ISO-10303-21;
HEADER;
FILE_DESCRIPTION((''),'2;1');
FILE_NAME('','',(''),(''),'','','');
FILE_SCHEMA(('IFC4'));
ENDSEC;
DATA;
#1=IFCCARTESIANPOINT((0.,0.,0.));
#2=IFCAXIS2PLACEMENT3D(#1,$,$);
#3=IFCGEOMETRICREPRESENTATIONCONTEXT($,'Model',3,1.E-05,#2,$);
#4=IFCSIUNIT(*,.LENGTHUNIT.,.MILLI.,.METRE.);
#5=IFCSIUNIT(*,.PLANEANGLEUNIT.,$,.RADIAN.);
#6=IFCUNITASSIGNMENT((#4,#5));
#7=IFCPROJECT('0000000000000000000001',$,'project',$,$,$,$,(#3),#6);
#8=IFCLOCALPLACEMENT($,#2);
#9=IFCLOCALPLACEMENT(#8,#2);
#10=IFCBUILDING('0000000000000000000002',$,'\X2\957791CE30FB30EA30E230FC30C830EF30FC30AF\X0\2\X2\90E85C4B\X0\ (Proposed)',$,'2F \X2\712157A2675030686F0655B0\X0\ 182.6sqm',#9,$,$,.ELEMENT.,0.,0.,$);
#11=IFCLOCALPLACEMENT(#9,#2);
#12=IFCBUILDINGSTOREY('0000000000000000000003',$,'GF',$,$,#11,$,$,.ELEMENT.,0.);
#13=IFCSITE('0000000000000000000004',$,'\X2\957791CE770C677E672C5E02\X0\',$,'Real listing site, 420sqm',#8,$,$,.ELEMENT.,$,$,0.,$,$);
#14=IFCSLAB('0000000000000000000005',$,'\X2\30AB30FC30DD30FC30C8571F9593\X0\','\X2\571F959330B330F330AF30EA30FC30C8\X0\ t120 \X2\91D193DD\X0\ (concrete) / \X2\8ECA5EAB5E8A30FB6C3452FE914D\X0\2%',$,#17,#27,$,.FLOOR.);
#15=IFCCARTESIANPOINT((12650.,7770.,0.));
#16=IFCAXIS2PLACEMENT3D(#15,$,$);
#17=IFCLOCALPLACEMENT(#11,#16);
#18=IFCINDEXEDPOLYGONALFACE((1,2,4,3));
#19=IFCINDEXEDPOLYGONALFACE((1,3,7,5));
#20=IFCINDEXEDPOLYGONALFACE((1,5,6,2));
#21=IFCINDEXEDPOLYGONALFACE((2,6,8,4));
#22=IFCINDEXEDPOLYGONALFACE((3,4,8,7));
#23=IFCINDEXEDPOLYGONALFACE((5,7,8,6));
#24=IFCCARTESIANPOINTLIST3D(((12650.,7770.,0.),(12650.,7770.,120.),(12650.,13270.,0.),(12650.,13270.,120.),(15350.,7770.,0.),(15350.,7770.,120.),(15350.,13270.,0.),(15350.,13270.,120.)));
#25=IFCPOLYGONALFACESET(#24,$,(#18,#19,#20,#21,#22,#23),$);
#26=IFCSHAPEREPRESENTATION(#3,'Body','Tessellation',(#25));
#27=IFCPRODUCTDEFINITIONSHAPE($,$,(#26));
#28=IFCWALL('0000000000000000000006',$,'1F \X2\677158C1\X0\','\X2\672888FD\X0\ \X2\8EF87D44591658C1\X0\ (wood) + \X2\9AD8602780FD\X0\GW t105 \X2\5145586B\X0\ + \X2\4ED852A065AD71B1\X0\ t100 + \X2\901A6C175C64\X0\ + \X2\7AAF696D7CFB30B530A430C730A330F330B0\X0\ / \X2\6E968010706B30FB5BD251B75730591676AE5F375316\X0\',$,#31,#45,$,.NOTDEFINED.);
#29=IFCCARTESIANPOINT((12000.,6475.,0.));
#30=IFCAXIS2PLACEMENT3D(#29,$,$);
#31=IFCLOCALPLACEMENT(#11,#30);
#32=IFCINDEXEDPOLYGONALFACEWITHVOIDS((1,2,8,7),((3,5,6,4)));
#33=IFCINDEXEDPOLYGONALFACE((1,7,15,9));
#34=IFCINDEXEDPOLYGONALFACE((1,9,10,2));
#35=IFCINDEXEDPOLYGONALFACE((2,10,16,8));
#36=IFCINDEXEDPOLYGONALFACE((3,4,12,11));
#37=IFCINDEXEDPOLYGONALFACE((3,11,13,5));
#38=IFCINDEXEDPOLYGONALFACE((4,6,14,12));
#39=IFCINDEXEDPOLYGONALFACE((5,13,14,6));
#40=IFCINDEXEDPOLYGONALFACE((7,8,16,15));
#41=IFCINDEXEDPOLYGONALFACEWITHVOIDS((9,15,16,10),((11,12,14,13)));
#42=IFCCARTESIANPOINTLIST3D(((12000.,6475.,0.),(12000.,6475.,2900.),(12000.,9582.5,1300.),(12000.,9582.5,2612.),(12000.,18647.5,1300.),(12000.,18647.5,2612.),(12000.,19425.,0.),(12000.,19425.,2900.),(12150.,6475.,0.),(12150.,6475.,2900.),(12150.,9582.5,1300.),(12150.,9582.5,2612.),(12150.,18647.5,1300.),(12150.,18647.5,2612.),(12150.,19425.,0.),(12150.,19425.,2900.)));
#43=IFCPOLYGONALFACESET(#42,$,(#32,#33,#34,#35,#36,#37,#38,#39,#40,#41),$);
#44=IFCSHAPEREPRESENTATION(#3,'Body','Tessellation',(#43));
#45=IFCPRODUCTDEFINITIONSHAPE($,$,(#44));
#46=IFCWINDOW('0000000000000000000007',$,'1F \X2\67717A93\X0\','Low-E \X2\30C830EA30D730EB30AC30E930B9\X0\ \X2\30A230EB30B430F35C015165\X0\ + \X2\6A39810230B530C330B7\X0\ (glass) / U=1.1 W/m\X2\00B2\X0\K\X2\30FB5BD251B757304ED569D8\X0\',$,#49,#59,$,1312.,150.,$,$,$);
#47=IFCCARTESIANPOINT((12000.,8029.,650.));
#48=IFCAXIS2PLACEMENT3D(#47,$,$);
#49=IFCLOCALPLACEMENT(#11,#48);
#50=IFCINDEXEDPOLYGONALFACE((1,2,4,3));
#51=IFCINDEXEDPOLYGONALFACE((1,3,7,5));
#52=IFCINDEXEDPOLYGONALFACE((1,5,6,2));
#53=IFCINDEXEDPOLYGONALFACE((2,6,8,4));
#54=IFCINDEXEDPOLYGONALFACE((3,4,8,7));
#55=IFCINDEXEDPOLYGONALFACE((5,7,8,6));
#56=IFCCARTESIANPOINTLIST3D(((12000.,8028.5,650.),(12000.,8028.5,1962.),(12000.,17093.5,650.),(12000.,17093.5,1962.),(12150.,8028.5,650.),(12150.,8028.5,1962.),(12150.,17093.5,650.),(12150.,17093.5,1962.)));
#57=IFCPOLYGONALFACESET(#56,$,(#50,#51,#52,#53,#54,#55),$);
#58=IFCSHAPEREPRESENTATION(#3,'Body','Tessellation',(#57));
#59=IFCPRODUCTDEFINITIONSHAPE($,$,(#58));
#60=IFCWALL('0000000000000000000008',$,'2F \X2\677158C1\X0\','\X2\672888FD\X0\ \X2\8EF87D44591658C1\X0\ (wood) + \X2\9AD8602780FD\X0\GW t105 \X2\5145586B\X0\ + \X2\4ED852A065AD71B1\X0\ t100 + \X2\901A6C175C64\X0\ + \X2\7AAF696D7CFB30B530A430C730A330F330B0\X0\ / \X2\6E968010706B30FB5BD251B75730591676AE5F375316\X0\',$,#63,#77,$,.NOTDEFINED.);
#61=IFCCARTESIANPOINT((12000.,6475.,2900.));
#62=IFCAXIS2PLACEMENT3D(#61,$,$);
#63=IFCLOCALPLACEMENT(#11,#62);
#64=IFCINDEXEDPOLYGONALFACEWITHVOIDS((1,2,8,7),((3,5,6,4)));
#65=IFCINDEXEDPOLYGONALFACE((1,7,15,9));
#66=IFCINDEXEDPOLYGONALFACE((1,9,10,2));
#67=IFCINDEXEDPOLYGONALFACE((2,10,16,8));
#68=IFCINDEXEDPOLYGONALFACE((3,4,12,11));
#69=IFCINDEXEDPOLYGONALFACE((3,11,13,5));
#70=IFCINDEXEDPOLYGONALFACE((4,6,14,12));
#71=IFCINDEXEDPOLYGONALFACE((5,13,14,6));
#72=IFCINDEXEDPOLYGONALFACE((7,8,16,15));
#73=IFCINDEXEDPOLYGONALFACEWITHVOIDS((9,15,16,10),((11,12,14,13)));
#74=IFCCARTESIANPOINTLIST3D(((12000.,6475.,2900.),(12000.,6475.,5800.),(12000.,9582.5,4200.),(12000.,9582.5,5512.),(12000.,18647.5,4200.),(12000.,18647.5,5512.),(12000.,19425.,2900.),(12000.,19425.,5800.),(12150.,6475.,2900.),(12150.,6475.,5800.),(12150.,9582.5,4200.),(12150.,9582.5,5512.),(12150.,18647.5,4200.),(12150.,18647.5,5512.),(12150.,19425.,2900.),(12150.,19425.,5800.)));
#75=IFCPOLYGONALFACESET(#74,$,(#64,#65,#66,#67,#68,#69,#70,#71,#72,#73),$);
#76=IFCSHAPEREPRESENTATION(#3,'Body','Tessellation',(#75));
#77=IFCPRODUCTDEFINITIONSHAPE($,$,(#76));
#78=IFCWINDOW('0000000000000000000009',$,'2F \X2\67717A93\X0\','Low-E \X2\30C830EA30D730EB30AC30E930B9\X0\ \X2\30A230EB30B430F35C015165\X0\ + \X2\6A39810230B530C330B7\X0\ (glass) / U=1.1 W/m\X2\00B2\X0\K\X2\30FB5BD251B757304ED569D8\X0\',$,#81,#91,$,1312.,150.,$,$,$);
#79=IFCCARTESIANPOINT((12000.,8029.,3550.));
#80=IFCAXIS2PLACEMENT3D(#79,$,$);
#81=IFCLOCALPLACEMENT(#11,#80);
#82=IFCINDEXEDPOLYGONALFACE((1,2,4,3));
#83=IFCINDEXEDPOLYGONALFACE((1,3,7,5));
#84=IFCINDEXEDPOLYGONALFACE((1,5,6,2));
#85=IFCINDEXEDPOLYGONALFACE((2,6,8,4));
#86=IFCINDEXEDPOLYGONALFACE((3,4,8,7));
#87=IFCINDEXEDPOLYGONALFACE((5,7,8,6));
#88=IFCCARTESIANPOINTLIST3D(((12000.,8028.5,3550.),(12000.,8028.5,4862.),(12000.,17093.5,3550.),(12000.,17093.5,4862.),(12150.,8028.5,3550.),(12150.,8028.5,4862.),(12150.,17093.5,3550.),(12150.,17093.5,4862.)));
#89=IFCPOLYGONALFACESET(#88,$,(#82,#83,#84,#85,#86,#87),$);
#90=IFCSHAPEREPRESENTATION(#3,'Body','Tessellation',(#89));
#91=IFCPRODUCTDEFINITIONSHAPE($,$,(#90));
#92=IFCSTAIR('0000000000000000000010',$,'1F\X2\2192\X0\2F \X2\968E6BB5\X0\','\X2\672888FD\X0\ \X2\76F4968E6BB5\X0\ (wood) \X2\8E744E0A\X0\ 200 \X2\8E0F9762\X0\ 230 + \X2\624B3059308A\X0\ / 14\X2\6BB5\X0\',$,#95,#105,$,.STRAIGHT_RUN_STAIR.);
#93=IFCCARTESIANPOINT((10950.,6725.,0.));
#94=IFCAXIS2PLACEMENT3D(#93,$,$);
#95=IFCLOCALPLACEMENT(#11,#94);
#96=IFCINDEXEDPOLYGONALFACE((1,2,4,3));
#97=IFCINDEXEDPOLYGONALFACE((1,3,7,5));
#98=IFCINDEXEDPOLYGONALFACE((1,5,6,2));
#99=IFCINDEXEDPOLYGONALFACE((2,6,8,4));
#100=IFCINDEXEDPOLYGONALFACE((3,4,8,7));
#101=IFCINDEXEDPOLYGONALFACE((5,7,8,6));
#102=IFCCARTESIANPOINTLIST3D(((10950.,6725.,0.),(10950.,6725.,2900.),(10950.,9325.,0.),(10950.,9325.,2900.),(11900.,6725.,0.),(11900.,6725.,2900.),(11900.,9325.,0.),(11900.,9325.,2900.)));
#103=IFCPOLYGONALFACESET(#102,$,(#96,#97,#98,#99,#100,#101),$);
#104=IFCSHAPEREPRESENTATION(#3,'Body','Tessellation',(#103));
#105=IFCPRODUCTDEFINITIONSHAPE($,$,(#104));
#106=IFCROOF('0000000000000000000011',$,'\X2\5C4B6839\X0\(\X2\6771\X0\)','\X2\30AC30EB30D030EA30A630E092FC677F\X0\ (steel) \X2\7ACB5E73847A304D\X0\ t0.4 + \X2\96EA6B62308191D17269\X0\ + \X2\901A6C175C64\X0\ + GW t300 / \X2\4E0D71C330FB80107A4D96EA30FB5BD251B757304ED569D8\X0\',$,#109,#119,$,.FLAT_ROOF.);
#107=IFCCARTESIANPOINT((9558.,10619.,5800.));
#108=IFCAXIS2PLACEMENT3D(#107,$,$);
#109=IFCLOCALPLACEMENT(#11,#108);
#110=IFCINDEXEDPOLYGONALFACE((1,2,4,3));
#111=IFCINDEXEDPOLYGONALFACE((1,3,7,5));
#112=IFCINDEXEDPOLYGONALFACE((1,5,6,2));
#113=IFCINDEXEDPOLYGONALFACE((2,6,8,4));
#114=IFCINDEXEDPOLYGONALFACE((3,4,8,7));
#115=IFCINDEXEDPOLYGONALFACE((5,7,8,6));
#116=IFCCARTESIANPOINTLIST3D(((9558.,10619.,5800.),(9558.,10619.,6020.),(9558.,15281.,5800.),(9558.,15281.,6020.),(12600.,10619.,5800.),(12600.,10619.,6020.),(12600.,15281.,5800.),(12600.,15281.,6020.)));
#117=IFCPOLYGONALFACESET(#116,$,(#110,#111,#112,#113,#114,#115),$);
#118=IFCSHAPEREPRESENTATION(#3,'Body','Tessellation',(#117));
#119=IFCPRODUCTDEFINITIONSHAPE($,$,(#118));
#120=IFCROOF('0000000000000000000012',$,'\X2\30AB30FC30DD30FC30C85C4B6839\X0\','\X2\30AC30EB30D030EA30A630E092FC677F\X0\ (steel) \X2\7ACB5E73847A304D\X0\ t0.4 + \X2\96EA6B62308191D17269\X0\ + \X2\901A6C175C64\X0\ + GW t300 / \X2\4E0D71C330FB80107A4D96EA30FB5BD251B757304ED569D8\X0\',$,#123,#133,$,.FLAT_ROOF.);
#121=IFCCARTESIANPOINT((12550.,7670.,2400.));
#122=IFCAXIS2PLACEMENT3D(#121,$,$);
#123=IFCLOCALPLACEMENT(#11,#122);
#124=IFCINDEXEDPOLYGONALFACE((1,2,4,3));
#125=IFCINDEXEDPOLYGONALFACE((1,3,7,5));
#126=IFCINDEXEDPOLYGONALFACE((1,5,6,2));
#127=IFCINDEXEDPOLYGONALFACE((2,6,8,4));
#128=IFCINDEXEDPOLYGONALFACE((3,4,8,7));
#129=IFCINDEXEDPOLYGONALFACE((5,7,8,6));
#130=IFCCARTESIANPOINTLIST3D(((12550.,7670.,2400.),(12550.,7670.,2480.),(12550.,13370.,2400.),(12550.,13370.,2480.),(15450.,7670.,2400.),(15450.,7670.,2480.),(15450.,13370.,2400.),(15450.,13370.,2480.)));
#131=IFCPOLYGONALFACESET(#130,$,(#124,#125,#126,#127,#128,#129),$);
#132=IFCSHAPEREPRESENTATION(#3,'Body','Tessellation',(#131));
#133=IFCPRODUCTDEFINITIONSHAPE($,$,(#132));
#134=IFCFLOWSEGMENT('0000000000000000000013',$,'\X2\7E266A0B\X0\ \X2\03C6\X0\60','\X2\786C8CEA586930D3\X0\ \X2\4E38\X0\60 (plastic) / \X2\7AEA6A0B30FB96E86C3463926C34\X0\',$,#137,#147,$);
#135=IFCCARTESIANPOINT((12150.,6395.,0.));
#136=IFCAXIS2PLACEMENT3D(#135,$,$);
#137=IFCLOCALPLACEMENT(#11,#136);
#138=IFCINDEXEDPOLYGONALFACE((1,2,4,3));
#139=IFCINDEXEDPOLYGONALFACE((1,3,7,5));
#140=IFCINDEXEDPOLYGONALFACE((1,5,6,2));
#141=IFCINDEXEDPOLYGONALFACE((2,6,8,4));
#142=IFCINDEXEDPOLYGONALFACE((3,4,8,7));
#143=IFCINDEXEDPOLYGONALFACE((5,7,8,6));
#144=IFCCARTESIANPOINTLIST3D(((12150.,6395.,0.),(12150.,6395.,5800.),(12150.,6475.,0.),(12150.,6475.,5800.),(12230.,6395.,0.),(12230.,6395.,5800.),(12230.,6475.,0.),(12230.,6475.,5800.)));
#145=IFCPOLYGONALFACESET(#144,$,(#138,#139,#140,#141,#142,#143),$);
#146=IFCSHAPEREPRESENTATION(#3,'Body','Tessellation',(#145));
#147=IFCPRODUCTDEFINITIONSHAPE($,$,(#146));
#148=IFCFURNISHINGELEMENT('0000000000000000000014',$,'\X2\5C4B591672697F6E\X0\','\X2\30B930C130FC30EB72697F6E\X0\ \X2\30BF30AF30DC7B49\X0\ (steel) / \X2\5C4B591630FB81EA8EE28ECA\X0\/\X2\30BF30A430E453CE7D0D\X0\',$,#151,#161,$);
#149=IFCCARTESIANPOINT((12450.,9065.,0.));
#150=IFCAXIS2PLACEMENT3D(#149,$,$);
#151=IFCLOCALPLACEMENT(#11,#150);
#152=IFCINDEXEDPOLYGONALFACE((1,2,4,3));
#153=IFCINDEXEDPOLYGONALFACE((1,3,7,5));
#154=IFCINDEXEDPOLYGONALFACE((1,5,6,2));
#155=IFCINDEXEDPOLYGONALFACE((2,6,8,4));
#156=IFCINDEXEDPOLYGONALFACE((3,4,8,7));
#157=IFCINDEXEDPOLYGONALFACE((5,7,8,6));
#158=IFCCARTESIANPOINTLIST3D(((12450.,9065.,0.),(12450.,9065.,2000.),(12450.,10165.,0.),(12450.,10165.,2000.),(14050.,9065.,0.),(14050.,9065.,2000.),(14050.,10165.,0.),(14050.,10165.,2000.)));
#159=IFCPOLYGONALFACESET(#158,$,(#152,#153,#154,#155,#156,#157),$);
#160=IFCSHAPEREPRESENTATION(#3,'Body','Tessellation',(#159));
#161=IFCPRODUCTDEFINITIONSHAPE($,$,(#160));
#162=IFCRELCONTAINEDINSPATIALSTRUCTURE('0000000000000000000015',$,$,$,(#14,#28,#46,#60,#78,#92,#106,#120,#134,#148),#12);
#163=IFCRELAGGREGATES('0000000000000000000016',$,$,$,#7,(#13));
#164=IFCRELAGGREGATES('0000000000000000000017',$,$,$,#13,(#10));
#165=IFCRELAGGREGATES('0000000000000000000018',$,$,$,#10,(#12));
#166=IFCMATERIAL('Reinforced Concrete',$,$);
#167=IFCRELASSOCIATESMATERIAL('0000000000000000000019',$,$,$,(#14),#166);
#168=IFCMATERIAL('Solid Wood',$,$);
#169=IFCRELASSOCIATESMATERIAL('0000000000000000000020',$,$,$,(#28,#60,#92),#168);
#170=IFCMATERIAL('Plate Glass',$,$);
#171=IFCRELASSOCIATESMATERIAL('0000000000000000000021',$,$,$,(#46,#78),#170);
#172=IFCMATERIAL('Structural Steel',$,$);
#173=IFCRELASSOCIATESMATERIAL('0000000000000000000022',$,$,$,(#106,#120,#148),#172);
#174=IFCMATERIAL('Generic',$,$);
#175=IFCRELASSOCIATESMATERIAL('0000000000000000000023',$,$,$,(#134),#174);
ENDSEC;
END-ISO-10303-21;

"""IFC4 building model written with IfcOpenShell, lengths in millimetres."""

from ifc_helpers import new_model, si_unit, frame, frame_2d, origin, place, context, project, spatial, rectangle, extrude, material, element, fill, save


model = new_model("IFC4")

# Units and contexts
model_context = context("Model", 3, precision=1e-05, world=origin())
ifc_project = project(units=[si_unit("LENGTHUNIT", "METRE", prefix="MILLI"), si_unit("PLANEANGLEUNIT", "RADIAN")], contexts=[model_context])

# Site, building, storey
site_placement = place(None, origin())
site = spatial("IfcSite", under=ifc_project, at=site_placement, Name="長野県松本市", ObjectType="Real listing site, 420sqm", CompositionType="ELEMENT", RefElevation=0.0)
building_placement = place(site_placement, origin())
building = spatial("IfcBuilding", under=site, at=building_placement, Name="長野・リモートワーク2部屋 (Proposed)", ObjectType="2F 無垢材と漆喰 182.6sqm", CompositionType="ELEMENT", ElevationOfRefHeight=0.0, ElevationOfTerrain=0.0)
storey_placement = place(building_placement, origin())
storey = spatial("IfcBuildingStorey", under=building, at=storey_placement, Name="GF", CompositionType="ELEMENT", Elevation=0.0)

# Shared definitions
ifc_material_1 = material(Name="Solid Wood")
ifc_material_2 = material(Name="Structural Steel")

# Slab
ifc_material_3 = material(Name="Reinforced Concrete")
slab_placement = place(storey_placement, frame((12650.0, 7770.0, 0.0)))
element("IfcSlab", 1, at=slab_placement, inside=storey, material=ifc_material_3, Name="カーポート土間", Description="土間コンクリート t120 金鏝 (concrete) / 車庫床・水勾配2%", PredefinedType="FLOOR", context=model_context, shape_type="SweptSolid", body=[
    extrude(rectangle(XDim=2700.0, YDim=5500.0, at=frame_2d((1350.0, 2750.0))), frame((12650.0, 7770.0, 0.0)), (0.0, 0.0, 1.0), 120.0),
])

# Walls, openings, windows
wall_1_placement = place(storey_placement, frame((12000.0, 6475.0, 0.0)))
wall_1 = element("IfcWall", 2, at=wall_1_placement, inside=storey, material=ifc_material_1, Name="1F 東壁", Description="木製 軸組外壁 (wood) + 高性能GW t105 充填 + 付加断熱 t100 + 通気層 + 窯業系サイディング / 準耐火・寒冷地外皮強化", PredefinedType="NOTDEFINED", context=model_context, shape_type="SweptSolid", body=[
    extrude(rectangle(XDim=150.0, YDim=12950.0, at=frame_2d((75.0, 6475.0))), frame((12000.0, 6475.0, 0.0)), (0.0, 0.0, 1.0), 2900.0),
])
opening_1_placement = place(storey_placement, frame((12000.0, 8029.0, 650.0)))
opening_1 = element("IfcOpeningElement", 3, at=opening_1_placement, cuts=wall_1, PredefinedType="NOTDEFINED", context=model_context, shape_type="SweptSolid", body=[
    extrude(rectangle(XDim=150.0, YDim=9065.0, at=frame_2d((75.0, 4532.0))), frame((12000.0, 8029.0, 650.0)), (0.0, 0.0, 1.0), 1312.0),
])
ifc_material_4 = material(Name="Plate Glass")
window_1_placement = place(storey_placement, frame((12000.0, 8029.0, 650.0)))
window_1 = element("IfcWindow", 4, at=window_1_placement, inside=storey, material=ifc_material_4, Name="1F 東窓", Description="Low-E トリプルガラス アルゴン封入 + 樹脂サッシ (glass) / U=1.1 W/m²K・寒冷地仕様", OverallHeight=1312.0, OverallWidth=150.0, context=model_context, shape_type="SweptSolid", body=[
    extrude(rectangle(XDim=150.0, YDim=9065.0, at=frame_2d((75.0, 4532.0))), frame((12000.0, 8029.0, 650.0)), (0.0, 0.0, 1.0), 1312.0),
])
fill(opening_1, window_1)
wall_2_placement = place(storey_placement, frame((12000.0, 6475.0, 2900.0)))
wall_2 = element("IfcWall", 5, at=wall_2_placement, inside=storey, material=ifc_material_1, Name="2F 東壁", Description="木製 軸組外壁 (wood) + 高性能GW t105 充填 + 付加断熱 t100 + 通気層 + 窯業系サイディング / 準耐火・寒冷地外皮強化", PredefinedType="NOTDEFINED", context=model_context, shape_type="SweptSolid", body=[
    extrude(rectangle(XDim=150.0, YDim=12950.0, at=frame_2d((75.0, 6475.0))), frame((12000.0, 6475.0, 2900.0)), (0.0, 0.0, 1.0), 2900.0),
])
opening_2_placement = place(storey_placement, frame((12000.0, 8029.0, 3550.0)))
opening_2 = element("IfcOpeningElement", 6, at=opening_2_placement, cuts=wall_2, PredefinedType="NOTDEFINED", context=model_context, shape_type="SweptSolid", body=[
    extrude(rectangle(XDim=150.0, YDim=9065.0, at=frame_2d((75.0, 4532.0))), frame((12000.0, 8029.0, 3550.0)), (0.0, 0.0, 1.0), 1312.0),
])
window_2_placement = place(storey_placement, frame((12000.0, 8029.0, 3550.0)))
window_2 = element("IfcWindow", 7, at=window_2_placement, inside=storey, material=ifc_material_4, Name="2F 東窓", Description="Low-E トリプルガラス アルゴン封入 + 樹脂サッシ (glass) / U=1.1 W/m²K・寒冷地仕様", OverallHeight=1312.0, OverallWidth=150.0, context=model_context, shape_type="SweptSolid", body=[
    extrude(rectangle(XDim=150.0, YDim=9065.0, at=frame_2d((75.0, 4532.0))), frame((12000.0, 8029.0, 3550.0)), (0.0, 0.0, 1.0), 1312.0),
])
fill(opening_2, window_2)

# Stair
stair_placement = place(storey_placement, frame((10950.0, 6725.0, 0.0)))
element("IfcStair", 8, at=stair_placement, inside=storey, material=ifc_material_1, Name="1F→2F 階段", Description="木製 直階段 (wood) 蹴上 200 踏面 230 + 手すり / 14段", PredefinedType="STRAIGHT_RUN_STAIR", context=model_context, shape_type="SweptSolid", body=[
    extrude(rectangle(XDim=950.0, YDim=2600.0, at=frame_2d((475.0, 1300.0))), frame((10950.0, 6725.0, 0.0)), (0.0, 0.0, 1.0), 2900.0),
])

# Roofs
roof_1_placement = place(storey_placement, frame((9558.0, 10619.0, 5800.0)))
element("IfcRoof", 9, at=roof_1_placement, inside=storey, material=ifc_material_2, Name="屋根(東)", Description="ガルバリウム鋼板 (steel) 立平葺き t0.4 + 雪止め金物 + 通気層 + GW t300 / 不燃・耐積雪・寒冷地仕様", PredefinedType="FLAT_ROOF", context=model_context, shape_type="SweptSolid", body=[
    extrude(rectangle(XDim=3042.0, YDim=4662.0, at=frame_2d((1521.0, 2331.0))), frame((9558.0, 10619.0, 5800.0)), (0.0, 0.0, 1.0), 220.0),
])
roof_2_placement = place(storey_placement, frame((12550.0, 7670.0, 2400.0)))
element("IfcRoof", 10, at=roof_2_placement, inside=storey, material=ifc_material_2, Name="カーポート屋根", Description="ガルバリウム鋼板 (steel) 立平葺き t0.4 + 雪止め金物 + 通気層 + GW t300 / 不燃・耐積雪・寒冷地仕様", PredefinedType="FLAT_ROOF", context=model_context, shape_type="SweptSolid", body=[
    extrude(rectangle(XDim=2900.0, YDim=5700.0, at=frame_2d((1450.0, 2850.0))), frame((12550.0, 7670.0, 2400.0)), (0.0, 0.0, 1.0), 80.0),
])

# Flow segment
ifc_material_5 = material(Name="Generic")
flow_segment_placement = place(storey_placement, frame((12150.0, 6395.0, 0.0)))
element("IfcFlowSegment", 11, at=flow_segment_placement, inside=storey, material=ifc_material_5, Name="縦樋 φ60", Description="硬質塩ビ 丸60 (plastic) / 竪樋・雨水排水", context=model_context, shape_type="SweptSolid", body=[
    extrude(rectangle(XDim=80.0, YDim=80.0, at=frame_2d((40.0, 40.0))), frame((12150.0, 6395.0, 0.0)), (0.0, 0.0, 1.0), 5800.0),
])

# Furnishing element
furnishing_placement = place(storey_placement, frame((12450.0, 9065.0, 0.0)))
element("IfcFurnishingElement", 12, at=furnishing_placement, inside=storey, material=ifc_material_2, Name="屋外物置", Description="スチール物置 タクボ等 (steel) / 屋外・自転車/タイヤ収納", context=model_context, shape_type="SweptSolid", body=[
    extrude(rectangle(XDim=1600.0, YDim=1100.0, at=frame_2d((800.0, 550.0))), frame((12450.0, 9065.0, 0.0)), (0.0, 0.0, 1.0), 2000.0),
])

save(model, "model.ifc")
